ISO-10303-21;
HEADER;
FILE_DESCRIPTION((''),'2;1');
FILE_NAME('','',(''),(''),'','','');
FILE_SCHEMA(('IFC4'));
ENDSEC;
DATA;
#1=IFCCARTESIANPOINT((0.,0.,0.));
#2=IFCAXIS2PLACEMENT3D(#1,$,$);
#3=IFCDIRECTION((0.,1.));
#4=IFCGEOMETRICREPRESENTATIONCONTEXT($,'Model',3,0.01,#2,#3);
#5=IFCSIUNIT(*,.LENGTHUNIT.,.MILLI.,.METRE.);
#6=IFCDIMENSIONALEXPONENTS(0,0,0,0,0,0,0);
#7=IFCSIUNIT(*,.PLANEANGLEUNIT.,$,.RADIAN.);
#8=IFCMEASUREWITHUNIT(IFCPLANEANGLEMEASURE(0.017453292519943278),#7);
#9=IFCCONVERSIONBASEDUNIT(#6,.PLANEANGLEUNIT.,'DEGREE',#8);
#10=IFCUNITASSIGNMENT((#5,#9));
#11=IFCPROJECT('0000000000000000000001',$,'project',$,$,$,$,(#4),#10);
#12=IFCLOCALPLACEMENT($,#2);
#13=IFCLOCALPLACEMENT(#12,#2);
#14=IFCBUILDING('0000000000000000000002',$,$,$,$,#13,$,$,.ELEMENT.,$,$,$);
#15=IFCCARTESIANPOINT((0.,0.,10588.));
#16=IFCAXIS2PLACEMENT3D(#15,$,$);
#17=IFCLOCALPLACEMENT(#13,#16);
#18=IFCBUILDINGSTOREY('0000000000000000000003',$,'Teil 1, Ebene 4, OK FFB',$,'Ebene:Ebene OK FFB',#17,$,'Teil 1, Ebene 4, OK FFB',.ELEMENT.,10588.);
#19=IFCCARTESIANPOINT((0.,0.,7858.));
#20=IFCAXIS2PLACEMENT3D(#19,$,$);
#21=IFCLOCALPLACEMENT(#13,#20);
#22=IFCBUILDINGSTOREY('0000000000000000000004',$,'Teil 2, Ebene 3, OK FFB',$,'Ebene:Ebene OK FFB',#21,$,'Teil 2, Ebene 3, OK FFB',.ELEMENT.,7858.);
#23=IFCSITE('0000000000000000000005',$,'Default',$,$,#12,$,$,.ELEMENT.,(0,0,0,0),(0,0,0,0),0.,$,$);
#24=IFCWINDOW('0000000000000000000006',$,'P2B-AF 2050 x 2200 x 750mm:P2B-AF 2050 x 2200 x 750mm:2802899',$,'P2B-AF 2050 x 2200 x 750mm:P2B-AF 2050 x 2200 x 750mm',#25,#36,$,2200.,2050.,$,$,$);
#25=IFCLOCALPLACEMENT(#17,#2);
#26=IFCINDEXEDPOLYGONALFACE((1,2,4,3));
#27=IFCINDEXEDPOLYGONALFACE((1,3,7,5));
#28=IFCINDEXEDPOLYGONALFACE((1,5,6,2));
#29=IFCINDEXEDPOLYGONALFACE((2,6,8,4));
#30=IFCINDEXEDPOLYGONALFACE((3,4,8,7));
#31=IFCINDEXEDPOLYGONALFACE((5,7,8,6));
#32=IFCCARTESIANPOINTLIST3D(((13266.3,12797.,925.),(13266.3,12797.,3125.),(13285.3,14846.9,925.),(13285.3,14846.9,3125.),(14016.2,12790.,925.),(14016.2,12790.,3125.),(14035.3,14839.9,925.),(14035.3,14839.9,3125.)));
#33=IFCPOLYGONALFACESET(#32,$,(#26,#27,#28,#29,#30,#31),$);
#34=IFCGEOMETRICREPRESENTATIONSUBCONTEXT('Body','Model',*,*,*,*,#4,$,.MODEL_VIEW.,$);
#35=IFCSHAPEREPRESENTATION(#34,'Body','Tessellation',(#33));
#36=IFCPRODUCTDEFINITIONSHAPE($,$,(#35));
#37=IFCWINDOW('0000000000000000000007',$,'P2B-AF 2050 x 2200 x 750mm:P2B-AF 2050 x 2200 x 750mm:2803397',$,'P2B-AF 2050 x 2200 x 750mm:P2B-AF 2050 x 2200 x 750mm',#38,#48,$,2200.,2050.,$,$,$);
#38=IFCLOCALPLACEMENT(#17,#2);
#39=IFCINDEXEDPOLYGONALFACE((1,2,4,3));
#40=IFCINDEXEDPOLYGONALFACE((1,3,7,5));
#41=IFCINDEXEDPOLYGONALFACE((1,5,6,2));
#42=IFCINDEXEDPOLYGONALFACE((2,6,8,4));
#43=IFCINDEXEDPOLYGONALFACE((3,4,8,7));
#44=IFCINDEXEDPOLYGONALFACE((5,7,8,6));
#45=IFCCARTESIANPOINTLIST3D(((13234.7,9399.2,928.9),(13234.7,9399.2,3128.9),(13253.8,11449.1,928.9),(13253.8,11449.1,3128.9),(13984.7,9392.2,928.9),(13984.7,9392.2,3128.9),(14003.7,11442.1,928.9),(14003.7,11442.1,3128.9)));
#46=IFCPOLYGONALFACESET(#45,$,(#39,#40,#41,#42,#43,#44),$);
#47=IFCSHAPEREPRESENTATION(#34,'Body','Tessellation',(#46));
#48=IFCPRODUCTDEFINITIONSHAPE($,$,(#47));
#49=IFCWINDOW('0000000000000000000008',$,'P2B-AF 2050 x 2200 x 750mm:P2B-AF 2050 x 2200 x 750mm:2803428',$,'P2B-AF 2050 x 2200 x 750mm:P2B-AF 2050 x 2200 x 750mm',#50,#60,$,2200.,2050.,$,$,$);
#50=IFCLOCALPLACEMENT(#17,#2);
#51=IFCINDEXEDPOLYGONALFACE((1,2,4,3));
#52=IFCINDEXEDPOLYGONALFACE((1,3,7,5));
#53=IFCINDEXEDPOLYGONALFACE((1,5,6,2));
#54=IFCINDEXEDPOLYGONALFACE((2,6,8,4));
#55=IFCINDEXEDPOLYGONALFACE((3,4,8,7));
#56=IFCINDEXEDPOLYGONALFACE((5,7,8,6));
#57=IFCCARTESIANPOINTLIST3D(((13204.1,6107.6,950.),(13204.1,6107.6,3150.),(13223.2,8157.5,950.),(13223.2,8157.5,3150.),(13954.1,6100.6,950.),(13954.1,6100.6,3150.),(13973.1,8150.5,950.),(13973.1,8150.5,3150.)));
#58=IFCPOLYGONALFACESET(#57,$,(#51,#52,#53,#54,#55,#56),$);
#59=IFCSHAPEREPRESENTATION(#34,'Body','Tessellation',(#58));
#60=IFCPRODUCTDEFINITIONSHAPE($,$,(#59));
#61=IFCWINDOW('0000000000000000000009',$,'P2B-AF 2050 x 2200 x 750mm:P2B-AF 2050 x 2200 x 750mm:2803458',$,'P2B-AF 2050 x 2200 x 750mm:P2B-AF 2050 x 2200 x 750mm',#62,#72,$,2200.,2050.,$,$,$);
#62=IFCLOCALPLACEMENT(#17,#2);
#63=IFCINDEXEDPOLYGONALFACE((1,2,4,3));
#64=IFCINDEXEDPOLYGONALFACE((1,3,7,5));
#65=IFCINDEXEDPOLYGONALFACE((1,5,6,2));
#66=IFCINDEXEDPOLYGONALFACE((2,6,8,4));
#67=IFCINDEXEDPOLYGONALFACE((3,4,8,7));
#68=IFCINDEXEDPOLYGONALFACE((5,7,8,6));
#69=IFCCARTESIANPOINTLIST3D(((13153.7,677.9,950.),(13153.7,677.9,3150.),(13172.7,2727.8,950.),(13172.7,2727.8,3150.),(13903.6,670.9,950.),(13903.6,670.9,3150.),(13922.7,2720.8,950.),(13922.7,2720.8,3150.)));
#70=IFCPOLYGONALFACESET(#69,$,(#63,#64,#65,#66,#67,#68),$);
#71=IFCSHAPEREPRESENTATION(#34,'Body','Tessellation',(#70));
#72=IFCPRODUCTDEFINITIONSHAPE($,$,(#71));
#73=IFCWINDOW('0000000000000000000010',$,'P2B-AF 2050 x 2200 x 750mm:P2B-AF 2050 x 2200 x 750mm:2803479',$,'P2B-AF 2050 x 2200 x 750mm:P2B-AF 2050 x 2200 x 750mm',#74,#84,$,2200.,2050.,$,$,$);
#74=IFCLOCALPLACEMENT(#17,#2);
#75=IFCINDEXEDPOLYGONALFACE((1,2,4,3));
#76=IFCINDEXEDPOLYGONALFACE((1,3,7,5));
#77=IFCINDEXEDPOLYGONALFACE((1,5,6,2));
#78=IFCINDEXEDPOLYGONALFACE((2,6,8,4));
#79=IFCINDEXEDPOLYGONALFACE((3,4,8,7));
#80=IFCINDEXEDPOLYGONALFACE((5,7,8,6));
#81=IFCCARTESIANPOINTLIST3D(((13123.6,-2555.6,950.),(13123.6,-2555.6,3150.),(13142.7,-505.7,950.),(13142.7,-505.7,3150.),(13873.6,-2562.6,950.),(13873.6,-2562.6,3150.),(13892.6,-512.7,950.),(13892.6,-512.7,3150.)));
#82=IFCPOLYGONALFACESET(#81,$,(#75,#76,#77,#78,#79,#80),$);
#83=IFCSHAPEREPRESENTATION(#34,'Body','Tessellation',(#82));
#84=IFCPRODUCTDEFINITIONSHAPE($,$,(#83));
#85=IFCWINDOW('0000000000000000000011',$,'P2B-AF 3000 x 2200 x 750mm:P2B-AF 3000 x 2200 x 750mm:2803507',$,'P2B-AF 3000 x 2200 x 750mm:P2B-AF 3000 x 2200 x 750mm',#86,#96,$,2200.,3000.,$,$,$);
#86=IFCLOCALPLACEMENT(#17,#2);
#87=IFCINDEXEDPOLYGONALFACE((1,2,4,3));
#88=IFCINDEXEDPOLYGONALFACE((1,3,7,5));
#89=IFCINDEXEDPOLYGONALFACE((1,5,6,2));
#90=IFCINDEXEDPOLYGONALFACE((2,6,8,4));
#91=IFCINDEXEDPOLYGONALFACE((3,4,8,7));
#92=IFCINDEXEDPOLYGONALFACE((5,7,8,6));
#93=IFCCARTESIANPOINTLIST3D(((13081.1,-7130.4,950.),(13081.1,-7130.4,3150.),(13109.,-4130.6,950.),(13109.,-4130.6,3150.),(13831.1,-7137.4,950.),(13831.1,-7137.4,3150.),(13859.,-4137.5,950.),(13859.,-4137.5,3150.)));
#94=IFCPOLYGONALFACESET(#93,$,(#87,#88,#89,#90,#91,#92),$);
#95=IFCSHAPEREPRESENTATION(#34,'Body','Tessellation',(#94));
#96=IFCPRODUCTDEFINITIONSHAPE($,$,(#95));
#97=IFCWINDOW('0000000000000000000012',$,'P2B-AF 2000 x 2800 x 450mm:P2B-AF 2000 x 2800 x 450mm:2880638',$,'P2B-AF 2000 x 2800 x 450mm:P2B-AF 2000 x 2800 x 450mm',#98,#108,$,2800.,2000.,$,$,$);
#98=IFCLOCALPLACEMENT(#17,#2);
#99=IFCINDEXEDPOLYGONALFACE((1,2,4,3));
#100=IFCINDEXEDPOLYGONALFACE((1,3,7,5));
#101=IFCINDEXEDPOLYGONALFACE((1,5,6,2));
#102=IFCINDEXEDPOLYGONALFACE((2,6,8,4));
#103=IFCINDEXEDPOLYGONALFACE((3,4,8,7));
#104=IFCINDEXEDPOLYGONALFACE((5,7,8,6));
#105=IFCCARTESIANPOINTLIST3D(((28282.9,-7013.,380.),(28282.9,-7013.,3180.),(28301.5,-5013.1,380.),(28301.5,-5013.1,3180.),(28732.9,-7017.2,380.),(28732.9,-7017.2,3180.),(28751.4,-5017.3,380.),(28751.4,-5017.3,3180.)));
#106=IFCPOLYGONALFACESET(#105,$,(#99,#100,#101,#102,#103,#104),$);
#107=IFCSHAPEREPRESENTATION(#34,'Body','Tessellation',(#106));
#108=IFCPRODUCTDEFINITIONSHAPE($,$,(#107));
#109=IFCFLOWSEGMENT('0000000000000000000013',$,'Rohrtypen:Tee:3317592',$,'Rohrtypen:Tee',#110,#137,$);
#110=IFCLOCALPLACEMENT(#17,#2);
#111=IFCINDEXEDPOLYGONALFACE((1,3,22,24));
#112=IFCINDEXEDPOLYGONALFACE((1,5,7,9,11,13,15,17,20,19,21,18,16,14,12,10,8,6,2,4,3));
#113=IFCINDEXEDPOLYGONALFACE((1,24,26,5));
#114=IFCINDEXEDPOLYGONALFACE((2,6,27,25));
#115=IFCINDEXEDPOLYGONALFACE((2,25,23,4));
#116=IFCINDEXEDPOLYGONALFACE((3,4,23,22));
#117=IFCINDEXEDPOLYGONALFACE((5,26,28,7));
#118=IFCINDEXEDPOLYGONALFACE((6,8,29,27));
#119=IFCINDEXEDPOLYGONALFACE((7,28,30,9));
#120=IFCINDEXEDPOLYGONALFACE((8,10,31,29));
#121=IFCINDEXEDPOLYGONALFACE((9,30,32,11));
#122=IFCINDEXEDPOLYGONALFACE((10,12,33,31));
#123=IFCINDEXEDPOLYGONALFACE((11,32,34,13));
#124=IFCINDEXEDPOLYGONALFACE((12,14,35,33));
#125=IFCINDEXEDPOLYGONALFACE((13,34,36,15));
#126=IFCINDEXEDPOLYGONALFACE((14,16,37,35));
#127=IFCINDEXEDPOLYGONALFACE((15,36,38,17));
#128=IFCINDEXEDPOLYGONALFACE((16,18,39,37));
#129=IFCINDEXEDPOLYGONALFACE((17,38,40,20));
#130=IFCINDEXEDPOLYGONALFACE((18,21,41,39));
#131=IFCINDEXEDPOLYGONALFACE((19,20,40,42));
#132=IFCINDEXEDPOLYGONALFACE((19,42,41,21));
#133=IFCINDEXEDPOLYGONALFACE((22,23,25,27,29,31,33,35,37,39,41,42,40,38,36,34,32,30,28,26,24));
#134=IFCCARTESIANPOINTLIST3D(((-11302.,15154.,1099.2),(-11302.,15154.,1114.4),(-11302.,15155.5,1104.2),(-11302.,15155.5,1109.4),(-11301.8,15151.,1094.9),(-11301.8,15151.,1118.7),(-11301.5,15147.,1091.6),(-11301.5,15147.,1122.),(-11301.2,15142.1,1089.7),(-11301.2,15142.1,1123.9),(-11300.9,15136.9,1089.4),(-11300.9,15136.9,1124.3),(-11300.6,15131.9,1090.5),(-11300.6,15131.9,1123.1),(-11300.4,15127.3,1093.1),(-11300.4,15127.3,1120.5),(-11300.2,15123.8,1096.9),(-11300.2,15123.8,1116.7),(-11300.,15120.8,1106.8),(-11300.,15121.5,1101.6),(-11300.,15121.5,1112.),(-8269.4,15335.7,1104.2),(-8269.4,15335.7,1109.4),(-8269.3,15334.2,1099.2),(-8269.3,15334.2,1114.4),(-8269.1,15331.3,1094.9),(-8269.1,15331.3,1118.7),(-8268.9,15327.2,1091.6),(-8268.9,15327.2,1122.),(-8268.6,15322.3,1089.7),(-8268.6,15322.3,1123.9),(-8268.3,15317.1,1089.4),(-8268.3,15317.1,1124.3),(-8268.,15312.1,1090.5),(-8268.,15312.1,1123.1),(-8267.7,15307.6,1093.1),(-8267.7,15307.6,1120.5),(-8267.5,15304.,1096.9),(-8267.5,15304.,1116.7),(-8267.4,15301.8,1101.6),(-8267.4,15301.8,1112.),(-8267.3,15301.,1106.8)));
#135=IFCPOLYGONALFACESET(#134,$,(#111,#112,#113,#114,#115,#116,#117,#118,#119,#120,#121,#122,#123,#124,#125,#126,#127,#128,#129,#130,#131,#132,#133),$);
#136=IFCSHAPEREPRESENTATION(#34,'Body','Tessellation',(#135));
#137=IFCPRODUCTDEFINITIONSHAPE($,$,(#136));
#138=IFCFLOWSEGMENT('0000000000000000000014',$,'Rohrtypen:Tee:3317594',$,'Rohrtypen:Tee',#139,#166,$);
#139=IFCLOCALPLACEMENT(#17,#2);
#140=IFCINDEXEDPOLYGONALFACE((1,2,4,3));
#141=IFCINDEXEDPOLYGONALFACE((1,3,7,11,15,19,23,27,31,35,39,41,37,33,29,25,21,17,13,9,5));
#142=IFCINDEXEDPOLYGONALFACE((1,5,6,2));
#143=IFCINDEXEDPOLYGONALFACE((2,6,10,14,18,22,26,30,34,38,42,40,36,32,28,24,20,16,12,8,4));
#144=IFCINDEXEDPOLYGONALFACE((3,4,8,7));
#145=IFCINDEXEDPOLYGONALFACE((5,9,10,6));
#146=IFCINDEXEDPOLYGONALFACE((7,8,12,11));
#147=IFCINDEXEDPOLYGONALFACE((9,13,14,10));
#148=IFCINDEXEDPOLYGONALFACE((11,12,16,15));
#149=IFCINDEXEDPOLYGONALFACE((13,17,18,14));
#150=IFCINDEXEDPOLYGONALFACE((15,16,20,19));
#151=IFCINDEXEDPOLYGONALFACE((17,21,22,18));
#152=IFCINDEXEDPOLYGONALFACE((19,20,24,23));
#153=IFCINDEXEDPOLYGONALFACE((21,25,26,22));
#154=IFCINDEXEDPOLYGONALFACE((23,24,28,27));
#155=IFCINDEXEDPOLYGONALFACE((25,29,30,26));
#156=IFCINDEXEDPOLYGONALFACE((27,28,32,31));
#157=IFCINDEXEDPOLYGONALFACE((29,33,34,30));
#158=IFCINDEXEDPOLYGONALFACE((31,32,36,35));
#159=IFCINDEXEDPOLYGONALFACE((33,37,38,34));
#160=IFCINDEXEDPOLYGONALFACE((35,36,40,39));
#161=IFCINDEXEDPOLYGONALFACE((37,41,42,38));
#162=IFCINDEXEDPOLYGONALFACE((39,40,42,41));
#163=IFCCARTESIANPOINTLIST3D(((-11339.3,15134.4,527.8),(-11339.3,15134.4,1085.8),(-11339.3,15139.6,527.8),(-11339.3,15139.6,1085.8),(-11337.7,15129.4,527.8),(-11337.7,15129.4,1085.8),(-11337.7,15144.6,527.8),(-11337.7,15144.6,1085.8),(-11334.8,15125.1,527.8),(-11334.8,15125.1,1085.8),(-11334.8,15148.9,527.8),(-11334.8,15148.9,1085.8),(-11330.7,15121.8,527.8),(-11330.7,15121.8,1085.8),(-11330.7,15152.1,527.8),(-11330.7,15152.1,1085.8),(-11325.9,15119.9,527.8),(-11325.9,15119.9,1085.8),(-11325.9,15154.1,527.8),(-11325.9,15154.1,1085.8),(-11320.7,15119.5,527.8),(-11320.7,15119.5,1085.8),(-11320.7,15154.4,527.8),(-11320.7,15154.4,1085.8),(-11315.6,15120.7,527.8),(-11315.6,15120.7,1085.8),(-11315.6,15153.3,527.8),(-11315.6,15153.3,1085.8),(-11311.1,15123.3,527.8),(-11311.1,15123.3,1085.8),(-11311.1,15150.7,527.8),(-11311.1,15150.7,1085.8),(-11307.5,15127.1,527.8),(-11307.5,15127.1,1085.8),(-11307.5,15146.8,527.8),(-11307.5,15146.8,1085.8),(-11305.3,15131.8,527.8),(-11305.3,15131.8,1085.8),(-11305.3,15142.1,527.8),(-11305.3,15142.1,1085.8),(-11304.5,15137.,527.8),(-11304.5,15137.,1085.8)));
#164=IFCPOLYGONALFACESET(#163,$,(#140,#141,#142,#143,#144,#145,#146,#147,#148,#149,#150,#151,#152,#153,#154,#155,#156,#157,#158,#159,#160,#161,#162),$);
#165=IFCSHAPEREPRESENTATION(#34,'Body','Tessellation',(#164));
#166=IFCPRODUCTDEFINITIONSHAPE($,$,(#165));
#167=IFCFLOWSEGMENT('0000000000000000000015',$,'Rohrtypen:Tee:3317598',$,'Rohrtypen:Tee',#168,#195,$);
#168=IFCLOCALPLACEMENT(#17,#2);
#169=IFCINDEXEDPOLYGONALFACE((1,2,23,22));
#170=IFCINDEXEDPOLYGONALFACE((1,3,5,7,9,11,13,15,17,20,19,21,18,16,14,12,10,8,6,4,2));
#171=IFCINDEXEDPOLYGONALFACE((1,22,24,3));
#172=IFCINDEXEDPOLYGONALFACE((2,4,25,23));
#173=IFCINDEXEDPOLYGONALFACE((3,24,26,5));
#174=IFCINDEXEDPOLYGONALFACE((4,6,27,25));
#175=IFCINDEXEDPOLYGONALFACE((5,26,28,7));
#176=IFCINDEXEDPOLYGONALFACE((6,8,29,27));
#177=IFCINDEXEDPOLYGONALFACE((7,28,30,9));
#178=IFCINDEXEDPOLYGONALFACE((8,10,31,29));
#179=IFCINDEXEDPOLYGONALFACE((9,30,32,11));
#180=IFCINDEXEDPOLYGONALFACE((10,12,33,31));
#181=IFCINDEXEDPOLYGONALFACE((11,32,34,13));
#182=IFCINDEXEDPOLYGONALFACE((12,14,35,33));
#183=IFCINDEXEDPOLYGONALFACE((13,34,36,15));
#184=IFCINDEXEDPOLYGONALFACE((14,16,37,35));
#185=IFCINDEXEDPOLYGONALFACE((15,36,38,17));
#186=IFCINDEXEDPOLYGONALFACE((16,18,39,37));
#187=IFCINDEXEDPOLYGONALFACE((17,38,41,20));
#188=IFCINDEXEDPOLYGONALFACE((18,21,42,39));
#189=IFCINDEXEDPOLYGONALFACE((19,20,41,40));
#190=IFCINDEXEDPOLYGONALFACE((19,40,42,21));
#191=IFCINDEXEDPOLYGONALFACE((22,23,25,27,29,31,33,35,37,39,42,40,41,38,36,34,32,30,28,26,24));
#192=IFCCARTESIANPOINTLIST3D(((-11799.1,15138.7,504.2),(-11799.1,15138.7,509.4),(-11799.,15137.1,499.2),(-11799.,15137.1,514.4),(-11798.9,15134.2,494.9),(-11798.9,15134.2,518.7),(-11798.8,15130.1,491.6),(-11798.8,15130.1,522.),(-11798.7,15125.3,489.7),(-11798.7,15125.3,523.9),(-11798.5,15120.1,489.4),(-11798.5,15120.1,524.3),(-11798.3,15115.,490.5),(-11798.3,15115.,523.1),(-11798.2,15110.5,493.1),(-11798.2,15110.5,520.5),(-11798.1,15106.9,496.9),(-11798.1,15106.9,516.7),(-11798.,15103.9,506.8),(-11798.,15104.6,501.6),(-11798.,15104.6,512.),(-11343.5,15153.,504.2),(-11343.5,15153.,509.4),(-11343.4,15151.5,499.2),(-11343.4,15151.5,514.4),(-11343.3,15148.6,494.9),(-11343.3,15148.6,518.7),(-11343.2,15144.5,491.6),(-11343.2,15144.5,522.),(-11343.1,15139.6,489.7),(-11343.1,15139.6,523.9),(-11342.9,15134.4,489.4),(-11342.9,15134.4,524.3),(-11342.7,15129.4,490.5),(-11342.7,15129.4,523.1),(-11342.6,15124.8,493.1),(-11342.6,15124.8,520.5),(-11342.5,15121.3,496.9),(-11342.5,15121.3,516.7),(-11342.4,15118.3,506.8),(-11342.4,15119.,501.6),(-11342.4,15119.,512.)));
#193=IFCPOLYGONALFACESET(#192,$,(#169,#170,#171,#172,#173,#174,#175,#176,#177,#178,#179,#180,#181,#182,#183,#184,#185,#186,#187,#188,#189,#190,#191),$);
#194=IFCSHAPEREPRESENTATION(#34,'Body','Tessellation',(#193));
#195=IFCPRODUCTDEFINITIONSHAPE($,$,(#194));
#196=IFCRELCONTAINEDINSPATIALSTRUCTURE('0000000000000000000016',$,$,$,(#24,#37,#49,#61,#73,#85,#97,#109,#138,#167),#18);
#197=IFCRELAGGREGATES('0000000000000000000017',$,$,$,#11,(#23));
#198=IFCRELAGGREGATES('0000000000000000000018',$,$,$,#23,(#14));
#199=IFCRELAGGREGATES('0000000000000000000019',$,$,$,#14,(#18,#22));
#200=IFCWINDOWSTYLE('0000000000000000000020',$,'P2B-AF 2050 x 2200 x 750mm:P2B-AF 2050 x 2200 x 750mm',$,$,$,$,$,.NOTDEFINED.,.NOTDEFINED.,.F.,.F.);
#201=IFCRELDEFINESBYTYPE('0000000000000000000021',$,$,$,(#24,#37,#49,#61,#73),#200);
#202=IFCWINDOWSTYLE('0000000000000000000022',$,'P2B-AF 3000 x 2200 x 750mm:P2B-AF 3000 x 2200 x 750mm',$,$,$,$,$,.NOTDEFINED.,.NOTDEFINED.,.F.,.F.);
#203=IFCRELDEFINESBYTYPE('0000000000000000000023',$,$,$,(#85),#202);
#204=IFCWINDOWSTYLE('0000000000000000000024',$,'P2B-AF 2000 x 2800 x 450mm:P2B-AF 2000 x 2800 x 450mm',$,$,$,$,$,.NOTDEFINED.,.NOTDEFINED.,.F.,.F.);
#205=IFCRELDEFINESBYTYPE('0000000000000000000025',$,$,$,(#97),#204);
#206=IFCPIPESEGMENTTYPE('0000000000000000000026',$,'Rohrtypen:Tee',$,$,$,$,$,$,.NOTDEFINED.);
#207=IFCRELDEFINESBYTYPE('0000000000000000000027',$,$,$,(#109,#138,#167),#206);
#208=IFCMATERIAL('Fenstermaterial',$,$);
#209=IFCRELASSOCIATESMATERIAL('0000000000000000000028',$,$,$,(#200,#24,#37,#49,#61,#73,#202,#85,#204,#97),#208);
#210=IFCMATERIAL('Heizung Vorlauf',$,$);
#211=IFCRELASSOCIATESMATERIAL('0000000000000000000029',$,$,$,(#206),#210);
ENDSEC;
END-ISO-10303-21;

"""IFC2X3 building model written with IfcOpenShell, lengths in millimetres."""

from ifc_helpers import new_model, entity, si_unit, converted_unit, direction, frame, frame_2d, origin, origin_2d_with_axis, place, context, subcontext, project, spatial, rectangle, circle, extrude, source, transform, mapped, material, type_object, type_shapes, element, save


model = new_model("IFC2X3")

# Units and contexts
model_context = context("Model", 3, precision=0.01, world=origin(), true_north=direction((0.0, 1.0)))
body_context = subcontext(model_context, "Body", "Model", "MODEL_VIEW")
ifc_project = project(units=[si_unit("LENGTHUNIT", "METRE", prefix="MILLI"), converted_unit("PLANEANGLEUNIT", "DEGREE", entity("IfcPlaneAngleMeasure", 0.017453292519943278), si_unit("PLANEANGLEUNIT", "RADIAN"), dimensions=[0, 0, 0, 0, 0, 0, 0])], contexts=[model_context])

# Site, building, storey
site_placement = place(None, origin())
site = spatial("IfcSite", under=ifc_project, at=site_placement, Name="Default", CompositionType="ELEMENT", RefLatitude=(0, 0, 0, 0), RefLongitude=(0, 0, 0, 0), RefElevation=0.0)
building_placement = place(site_placement, origin())
building = spatial("IfcBuilding", under=site, at=building_placement, CompositionType="ELEMENT")
storey_1_placement = place(building_placement, frame((0.0, 0.0, 10588.0)))
storey_1 = spatial("IfcBuildingStorey", under=building, at=storey_1_placement, Name="Teil 1, Ebene 4, OK FFB", ObjectType="Ebene:Ebene OK FFB", LongName="Teil 1, Ebene 4, OK FFB", CompositionType="ELEMENT", Elevation=10588.0)

# Shared definitions
storey_2_placement = place(building_placement, frame((0.0, 0.0, 7858.0)))
storey_2 = spatial("IfcBuildingStorey", under=building, at=storey_2_placement, Name="Teil 2, Ebene 3, OK FFB", ObjectType="Ebene:Ebene OK FFB", LongName="Teil 2, Ebene 3, OK FFB", CompositionType="ELEMENT", Elevation=7858.0)

# Shared definitions
ifc_material_1 = material(Name="Fenstermaterial")

# Windows
window_style_1 = type_object("IfcWindowStyle", Name="P2B-AF 2050 x 2200 x 750mm:P2B-AF 2050 x 2200 x 750mm", ConstructionType="NOTDEFINED", OperationType="NOTDEFINED", ParameterTakesPrecedence=False, Sizeable=False, material=ifc_material_1)
shared_shape_1 = source(origin(), body_context, "Body", "SweptSolid", [
    extrude(rectangle(XDim=750.0, YDim=2050.0, at=frame_2d((0.0, 0.0), x_axis=(1.0, 0.0))), frame((1025.0, 375.0, 0.0), z_axis=(0.0, 0.0, 1.0), x_axis=(0.0, 1.0, 0.0)), (0.0, 0.0, 1.0), 2200.0),
])
type_shapes(window_style_1, [shared_shape_1])
for number, where, z_axis, x_axis, name in (
    (1, (14016.2, 12790.0, 925.0), (0.0, 0.0, 1.0), (0.009291, 0.999957, 0.0), "P2B-AF 2050 x 2200 x 750mm:P2B-AF 2050 x 2200 x 750mm:2802899"),
    (2, (13984.7, 9392.2, 928.9), (0.0, 0.0, 1.0), (0.009291, 0.999957, 0.0), "P2B-AF 2050 x 2200 x 750mm:P2B-AF 2050 x 2200 x 750mm:2803397"),
    (3, (13954.1, 6100.6, 950.0), (0.0, 0.0, 1.0), (0.009291, 0.999957, 0.0), "P2B-AF 2050 x 2200 x 750mm:P2B-AF 2050 x 2200 x 750mm:2803428"),
    (4, (13903.6, 670.9, 950.0), (0.0, 0.0, 1.0), (0.009291, 0.999957, 0.0), "P2B-AF 2050 x 2200 x 750mm:P2B-AF 2050 x 2200 x 750mm:2803458"),
    (5, (13873.6, -2562.6, 950.0), (0.0, 0.0, 1.0), (0.009291, 0.999957, 0.0), "P2B-AF 2050 x 2200 x 750mm:P2B-AF 2050 x 2200 x 750mm:2803479"),
):
    element("IfcWindow", number, at=place(storey_1_placement, frame(where, z_axis=z_axis, x_axis=x_axis)), inside=storey_1, type_object=window_style_1, material=ifc_material_1, Name=name, ObjectType="P2B-AF 2050 x 2200 x 750mm:P2B-AF 2050 x 2200 x 750mm", OverallHeight=2200.0, OverallWidth=2050.0, context=body_context, shape_type="MappedRepresentation", body=[
        mapped(shared_shape_1, transform((0.0, 0.0, 0.0), scale=1.0)),
    ])
window_style_2 = type_object("IfcWindowStyle", Name="P2B-AF 3000 x 2200 x 750mm:P2B-AF 3000 x 2200 x 750mm", ConstructionType="NOTDEFINED", OperationType="NOTDEFINED", ParameterTakesPrecedence=False, Sizeable=False, material=ifc_material_1)
shared_shape_2 = source(origin(), body_context, "Body", "SweptSolid", [
    extrude(rectangle(XDim=750.0, YDim=3000.0, at=frame_2d((0.0, 0.0), x_axis=(1.0, 0.0))), frame((1500.0, 375.0, 0.0), z_axis=(0.0, 0.0, 1.0), x_axis=(0.0, 1.0, 0.0)), (0.0, 0.0, 1.0), 2200.0),
])
type_shapes(window_style_2, [shared_shape_2])
window_1_placement = place(storey_1_placement, frame((13831.1, -7137.4, 950.0), z_axis=(0.0, 0.0, 1.0), x_axis=(0.009291, 0.999957, 0.0)))
element("IfcWindow", 6, at=window_1_placement, inside=storey_1, type_object=window_style_2, material=ifc_material_1, Name="P2B-AF 3000 x 2200 x 750mm:P2B-AF 3000 x 2200 x 750mm:2803507", ObjectType="P2B-AF 3000 x 2200 x 750mm:P2B-AF 3000 x 2200 x 750mm", OverallHeight=2200.0, OverallWidth=3000.0, context=body_context, shape_type="MappedRepresentation", body=[
    mapped(shared_shape_2, transform((0.0, 0.0, 0.0), scale=1.0)),
])
window_style_3 = type_object("IfcWindowStyle", Name="P2B-AF 2000 x 2800 x 450mm:P2B-AF 2000 x 2800 x 450mm", ConstructionType="NOTDEFINED", OperationType="NOTDEFINED", ParameterTakesPrecedence=False, Sizeable=False, material=ifc_material_1)
shared_shape_3 = source(origin(), body_context, "Body", "SweptSolid", [
    extrude(rectangle(XDim=450.0, YDim=2000.0, at=frame_2d((0.0, 0.0), x_axis=(1.0, 0.0))), frame((1000.0, 225.0, 0.0), z_axis=(0.0, 0.0, 1.0), x_axis=(0.0, 1.0, 0.0)), (0.0, 0.0, 1.0), 2800.0),
])
type_shapes(window_style_3, [shared_shape_3])
window_2_placement = place(storey_1_placement, frame((28732.9, -7017.2, 380.0), z_axis=(0.0, 0.0, 1.0), x_axis=(0.009291, 0.999957, 0.0)))
element("IfcWindow", 7, at=window_2_placement, inside=storey_1, type_object=window_style_3, material=ifc_material_1, Name="P2B-AF 2000 x 2800 x 450mm:P2B-AF 2000 x 2800 x 450mm:2880638", ObjectType="P2B-AF 2000 x 2800 x 450mm:P2B-AF 2000 x 2800 x 450mm", OverallHeight=2800.0, OverallWidth=2000.0, context=body_context, shape_type="MappedRepresentation", body=[
    mapped(shared_shape_3, transform((0.0, 0.0, 0.0), scale=1.0)),
])

# Flow segments
ifc_material_2 = material(Name="Heizung Vorlauf")
pipe_segment_type = type_object("IfcPipeSegmentType", Name="Rohrtypen:Tee", PredefinedType="NOTDEFINED", material=ifc_material_2)
flow_segment_1_placement = place(storey_1_placement, origin())
element("IfcFlowSegment", 8, at=flow_segment_1_placement, inside=storey_1, type_object=pipe_segment_type, Name="Rohrtypen:Tee:3317592", ObjectType="Rohrtypen:Tee", context=body_context, shape_type="SweptSolid", body=[
    extrude(circle(Radius=17.5, at=origin_2d_with_axis()), frame((-11301.0, 15138.2, 1106.8), z_axis=(0.998239, 0.059319, 0.0), x_axis=(0.059319, -0.998239, 0.0)), (0.0, 0.0, 1.0), 3038.0),
])
flow_segment_2_placement = place(storey_1_placement, origin())
element("IfcFlowSegment", 9, at=flow_segment_2_placement, inside=storey_1, type_object=pipe_segment_type, Name="Rohrtypen:Tee:3317594", ObjectType="Rohrtypen:Tee", context=body_context, shape_type="SweptSolid", body=[
    extrude(circle(Radius=17.5, at=origin_2d_with_axis()), frame((-11322.0, 15137.0, 527.8)), (0.0, 0.0, 1.0), 558.0),
])
flow_segment_3_placement = place(storey_1_placement, origin())
element("IfcFlowSegment", 10, at=flow_segment_3_placement, inside=storey_1, type_object=pipe_segment_type, Name="Rohrtypen:Tee:3317598", ObjectType="Rohrtypen:Tee", context=body_context, shape_type="SweptSolid", body=[
    extrude(circle(Radius=17.5, at=origin_2d_with_axis()), frame((-11798.5, 15121.4, 506.8), z_axis=(0.999502, 0.031546, 0.0), x_axis=(0.031546, -0.999502, 0.0)), (0.0, 0.0, 1.0), 455.8),
])

save(model, "model.ifc")
